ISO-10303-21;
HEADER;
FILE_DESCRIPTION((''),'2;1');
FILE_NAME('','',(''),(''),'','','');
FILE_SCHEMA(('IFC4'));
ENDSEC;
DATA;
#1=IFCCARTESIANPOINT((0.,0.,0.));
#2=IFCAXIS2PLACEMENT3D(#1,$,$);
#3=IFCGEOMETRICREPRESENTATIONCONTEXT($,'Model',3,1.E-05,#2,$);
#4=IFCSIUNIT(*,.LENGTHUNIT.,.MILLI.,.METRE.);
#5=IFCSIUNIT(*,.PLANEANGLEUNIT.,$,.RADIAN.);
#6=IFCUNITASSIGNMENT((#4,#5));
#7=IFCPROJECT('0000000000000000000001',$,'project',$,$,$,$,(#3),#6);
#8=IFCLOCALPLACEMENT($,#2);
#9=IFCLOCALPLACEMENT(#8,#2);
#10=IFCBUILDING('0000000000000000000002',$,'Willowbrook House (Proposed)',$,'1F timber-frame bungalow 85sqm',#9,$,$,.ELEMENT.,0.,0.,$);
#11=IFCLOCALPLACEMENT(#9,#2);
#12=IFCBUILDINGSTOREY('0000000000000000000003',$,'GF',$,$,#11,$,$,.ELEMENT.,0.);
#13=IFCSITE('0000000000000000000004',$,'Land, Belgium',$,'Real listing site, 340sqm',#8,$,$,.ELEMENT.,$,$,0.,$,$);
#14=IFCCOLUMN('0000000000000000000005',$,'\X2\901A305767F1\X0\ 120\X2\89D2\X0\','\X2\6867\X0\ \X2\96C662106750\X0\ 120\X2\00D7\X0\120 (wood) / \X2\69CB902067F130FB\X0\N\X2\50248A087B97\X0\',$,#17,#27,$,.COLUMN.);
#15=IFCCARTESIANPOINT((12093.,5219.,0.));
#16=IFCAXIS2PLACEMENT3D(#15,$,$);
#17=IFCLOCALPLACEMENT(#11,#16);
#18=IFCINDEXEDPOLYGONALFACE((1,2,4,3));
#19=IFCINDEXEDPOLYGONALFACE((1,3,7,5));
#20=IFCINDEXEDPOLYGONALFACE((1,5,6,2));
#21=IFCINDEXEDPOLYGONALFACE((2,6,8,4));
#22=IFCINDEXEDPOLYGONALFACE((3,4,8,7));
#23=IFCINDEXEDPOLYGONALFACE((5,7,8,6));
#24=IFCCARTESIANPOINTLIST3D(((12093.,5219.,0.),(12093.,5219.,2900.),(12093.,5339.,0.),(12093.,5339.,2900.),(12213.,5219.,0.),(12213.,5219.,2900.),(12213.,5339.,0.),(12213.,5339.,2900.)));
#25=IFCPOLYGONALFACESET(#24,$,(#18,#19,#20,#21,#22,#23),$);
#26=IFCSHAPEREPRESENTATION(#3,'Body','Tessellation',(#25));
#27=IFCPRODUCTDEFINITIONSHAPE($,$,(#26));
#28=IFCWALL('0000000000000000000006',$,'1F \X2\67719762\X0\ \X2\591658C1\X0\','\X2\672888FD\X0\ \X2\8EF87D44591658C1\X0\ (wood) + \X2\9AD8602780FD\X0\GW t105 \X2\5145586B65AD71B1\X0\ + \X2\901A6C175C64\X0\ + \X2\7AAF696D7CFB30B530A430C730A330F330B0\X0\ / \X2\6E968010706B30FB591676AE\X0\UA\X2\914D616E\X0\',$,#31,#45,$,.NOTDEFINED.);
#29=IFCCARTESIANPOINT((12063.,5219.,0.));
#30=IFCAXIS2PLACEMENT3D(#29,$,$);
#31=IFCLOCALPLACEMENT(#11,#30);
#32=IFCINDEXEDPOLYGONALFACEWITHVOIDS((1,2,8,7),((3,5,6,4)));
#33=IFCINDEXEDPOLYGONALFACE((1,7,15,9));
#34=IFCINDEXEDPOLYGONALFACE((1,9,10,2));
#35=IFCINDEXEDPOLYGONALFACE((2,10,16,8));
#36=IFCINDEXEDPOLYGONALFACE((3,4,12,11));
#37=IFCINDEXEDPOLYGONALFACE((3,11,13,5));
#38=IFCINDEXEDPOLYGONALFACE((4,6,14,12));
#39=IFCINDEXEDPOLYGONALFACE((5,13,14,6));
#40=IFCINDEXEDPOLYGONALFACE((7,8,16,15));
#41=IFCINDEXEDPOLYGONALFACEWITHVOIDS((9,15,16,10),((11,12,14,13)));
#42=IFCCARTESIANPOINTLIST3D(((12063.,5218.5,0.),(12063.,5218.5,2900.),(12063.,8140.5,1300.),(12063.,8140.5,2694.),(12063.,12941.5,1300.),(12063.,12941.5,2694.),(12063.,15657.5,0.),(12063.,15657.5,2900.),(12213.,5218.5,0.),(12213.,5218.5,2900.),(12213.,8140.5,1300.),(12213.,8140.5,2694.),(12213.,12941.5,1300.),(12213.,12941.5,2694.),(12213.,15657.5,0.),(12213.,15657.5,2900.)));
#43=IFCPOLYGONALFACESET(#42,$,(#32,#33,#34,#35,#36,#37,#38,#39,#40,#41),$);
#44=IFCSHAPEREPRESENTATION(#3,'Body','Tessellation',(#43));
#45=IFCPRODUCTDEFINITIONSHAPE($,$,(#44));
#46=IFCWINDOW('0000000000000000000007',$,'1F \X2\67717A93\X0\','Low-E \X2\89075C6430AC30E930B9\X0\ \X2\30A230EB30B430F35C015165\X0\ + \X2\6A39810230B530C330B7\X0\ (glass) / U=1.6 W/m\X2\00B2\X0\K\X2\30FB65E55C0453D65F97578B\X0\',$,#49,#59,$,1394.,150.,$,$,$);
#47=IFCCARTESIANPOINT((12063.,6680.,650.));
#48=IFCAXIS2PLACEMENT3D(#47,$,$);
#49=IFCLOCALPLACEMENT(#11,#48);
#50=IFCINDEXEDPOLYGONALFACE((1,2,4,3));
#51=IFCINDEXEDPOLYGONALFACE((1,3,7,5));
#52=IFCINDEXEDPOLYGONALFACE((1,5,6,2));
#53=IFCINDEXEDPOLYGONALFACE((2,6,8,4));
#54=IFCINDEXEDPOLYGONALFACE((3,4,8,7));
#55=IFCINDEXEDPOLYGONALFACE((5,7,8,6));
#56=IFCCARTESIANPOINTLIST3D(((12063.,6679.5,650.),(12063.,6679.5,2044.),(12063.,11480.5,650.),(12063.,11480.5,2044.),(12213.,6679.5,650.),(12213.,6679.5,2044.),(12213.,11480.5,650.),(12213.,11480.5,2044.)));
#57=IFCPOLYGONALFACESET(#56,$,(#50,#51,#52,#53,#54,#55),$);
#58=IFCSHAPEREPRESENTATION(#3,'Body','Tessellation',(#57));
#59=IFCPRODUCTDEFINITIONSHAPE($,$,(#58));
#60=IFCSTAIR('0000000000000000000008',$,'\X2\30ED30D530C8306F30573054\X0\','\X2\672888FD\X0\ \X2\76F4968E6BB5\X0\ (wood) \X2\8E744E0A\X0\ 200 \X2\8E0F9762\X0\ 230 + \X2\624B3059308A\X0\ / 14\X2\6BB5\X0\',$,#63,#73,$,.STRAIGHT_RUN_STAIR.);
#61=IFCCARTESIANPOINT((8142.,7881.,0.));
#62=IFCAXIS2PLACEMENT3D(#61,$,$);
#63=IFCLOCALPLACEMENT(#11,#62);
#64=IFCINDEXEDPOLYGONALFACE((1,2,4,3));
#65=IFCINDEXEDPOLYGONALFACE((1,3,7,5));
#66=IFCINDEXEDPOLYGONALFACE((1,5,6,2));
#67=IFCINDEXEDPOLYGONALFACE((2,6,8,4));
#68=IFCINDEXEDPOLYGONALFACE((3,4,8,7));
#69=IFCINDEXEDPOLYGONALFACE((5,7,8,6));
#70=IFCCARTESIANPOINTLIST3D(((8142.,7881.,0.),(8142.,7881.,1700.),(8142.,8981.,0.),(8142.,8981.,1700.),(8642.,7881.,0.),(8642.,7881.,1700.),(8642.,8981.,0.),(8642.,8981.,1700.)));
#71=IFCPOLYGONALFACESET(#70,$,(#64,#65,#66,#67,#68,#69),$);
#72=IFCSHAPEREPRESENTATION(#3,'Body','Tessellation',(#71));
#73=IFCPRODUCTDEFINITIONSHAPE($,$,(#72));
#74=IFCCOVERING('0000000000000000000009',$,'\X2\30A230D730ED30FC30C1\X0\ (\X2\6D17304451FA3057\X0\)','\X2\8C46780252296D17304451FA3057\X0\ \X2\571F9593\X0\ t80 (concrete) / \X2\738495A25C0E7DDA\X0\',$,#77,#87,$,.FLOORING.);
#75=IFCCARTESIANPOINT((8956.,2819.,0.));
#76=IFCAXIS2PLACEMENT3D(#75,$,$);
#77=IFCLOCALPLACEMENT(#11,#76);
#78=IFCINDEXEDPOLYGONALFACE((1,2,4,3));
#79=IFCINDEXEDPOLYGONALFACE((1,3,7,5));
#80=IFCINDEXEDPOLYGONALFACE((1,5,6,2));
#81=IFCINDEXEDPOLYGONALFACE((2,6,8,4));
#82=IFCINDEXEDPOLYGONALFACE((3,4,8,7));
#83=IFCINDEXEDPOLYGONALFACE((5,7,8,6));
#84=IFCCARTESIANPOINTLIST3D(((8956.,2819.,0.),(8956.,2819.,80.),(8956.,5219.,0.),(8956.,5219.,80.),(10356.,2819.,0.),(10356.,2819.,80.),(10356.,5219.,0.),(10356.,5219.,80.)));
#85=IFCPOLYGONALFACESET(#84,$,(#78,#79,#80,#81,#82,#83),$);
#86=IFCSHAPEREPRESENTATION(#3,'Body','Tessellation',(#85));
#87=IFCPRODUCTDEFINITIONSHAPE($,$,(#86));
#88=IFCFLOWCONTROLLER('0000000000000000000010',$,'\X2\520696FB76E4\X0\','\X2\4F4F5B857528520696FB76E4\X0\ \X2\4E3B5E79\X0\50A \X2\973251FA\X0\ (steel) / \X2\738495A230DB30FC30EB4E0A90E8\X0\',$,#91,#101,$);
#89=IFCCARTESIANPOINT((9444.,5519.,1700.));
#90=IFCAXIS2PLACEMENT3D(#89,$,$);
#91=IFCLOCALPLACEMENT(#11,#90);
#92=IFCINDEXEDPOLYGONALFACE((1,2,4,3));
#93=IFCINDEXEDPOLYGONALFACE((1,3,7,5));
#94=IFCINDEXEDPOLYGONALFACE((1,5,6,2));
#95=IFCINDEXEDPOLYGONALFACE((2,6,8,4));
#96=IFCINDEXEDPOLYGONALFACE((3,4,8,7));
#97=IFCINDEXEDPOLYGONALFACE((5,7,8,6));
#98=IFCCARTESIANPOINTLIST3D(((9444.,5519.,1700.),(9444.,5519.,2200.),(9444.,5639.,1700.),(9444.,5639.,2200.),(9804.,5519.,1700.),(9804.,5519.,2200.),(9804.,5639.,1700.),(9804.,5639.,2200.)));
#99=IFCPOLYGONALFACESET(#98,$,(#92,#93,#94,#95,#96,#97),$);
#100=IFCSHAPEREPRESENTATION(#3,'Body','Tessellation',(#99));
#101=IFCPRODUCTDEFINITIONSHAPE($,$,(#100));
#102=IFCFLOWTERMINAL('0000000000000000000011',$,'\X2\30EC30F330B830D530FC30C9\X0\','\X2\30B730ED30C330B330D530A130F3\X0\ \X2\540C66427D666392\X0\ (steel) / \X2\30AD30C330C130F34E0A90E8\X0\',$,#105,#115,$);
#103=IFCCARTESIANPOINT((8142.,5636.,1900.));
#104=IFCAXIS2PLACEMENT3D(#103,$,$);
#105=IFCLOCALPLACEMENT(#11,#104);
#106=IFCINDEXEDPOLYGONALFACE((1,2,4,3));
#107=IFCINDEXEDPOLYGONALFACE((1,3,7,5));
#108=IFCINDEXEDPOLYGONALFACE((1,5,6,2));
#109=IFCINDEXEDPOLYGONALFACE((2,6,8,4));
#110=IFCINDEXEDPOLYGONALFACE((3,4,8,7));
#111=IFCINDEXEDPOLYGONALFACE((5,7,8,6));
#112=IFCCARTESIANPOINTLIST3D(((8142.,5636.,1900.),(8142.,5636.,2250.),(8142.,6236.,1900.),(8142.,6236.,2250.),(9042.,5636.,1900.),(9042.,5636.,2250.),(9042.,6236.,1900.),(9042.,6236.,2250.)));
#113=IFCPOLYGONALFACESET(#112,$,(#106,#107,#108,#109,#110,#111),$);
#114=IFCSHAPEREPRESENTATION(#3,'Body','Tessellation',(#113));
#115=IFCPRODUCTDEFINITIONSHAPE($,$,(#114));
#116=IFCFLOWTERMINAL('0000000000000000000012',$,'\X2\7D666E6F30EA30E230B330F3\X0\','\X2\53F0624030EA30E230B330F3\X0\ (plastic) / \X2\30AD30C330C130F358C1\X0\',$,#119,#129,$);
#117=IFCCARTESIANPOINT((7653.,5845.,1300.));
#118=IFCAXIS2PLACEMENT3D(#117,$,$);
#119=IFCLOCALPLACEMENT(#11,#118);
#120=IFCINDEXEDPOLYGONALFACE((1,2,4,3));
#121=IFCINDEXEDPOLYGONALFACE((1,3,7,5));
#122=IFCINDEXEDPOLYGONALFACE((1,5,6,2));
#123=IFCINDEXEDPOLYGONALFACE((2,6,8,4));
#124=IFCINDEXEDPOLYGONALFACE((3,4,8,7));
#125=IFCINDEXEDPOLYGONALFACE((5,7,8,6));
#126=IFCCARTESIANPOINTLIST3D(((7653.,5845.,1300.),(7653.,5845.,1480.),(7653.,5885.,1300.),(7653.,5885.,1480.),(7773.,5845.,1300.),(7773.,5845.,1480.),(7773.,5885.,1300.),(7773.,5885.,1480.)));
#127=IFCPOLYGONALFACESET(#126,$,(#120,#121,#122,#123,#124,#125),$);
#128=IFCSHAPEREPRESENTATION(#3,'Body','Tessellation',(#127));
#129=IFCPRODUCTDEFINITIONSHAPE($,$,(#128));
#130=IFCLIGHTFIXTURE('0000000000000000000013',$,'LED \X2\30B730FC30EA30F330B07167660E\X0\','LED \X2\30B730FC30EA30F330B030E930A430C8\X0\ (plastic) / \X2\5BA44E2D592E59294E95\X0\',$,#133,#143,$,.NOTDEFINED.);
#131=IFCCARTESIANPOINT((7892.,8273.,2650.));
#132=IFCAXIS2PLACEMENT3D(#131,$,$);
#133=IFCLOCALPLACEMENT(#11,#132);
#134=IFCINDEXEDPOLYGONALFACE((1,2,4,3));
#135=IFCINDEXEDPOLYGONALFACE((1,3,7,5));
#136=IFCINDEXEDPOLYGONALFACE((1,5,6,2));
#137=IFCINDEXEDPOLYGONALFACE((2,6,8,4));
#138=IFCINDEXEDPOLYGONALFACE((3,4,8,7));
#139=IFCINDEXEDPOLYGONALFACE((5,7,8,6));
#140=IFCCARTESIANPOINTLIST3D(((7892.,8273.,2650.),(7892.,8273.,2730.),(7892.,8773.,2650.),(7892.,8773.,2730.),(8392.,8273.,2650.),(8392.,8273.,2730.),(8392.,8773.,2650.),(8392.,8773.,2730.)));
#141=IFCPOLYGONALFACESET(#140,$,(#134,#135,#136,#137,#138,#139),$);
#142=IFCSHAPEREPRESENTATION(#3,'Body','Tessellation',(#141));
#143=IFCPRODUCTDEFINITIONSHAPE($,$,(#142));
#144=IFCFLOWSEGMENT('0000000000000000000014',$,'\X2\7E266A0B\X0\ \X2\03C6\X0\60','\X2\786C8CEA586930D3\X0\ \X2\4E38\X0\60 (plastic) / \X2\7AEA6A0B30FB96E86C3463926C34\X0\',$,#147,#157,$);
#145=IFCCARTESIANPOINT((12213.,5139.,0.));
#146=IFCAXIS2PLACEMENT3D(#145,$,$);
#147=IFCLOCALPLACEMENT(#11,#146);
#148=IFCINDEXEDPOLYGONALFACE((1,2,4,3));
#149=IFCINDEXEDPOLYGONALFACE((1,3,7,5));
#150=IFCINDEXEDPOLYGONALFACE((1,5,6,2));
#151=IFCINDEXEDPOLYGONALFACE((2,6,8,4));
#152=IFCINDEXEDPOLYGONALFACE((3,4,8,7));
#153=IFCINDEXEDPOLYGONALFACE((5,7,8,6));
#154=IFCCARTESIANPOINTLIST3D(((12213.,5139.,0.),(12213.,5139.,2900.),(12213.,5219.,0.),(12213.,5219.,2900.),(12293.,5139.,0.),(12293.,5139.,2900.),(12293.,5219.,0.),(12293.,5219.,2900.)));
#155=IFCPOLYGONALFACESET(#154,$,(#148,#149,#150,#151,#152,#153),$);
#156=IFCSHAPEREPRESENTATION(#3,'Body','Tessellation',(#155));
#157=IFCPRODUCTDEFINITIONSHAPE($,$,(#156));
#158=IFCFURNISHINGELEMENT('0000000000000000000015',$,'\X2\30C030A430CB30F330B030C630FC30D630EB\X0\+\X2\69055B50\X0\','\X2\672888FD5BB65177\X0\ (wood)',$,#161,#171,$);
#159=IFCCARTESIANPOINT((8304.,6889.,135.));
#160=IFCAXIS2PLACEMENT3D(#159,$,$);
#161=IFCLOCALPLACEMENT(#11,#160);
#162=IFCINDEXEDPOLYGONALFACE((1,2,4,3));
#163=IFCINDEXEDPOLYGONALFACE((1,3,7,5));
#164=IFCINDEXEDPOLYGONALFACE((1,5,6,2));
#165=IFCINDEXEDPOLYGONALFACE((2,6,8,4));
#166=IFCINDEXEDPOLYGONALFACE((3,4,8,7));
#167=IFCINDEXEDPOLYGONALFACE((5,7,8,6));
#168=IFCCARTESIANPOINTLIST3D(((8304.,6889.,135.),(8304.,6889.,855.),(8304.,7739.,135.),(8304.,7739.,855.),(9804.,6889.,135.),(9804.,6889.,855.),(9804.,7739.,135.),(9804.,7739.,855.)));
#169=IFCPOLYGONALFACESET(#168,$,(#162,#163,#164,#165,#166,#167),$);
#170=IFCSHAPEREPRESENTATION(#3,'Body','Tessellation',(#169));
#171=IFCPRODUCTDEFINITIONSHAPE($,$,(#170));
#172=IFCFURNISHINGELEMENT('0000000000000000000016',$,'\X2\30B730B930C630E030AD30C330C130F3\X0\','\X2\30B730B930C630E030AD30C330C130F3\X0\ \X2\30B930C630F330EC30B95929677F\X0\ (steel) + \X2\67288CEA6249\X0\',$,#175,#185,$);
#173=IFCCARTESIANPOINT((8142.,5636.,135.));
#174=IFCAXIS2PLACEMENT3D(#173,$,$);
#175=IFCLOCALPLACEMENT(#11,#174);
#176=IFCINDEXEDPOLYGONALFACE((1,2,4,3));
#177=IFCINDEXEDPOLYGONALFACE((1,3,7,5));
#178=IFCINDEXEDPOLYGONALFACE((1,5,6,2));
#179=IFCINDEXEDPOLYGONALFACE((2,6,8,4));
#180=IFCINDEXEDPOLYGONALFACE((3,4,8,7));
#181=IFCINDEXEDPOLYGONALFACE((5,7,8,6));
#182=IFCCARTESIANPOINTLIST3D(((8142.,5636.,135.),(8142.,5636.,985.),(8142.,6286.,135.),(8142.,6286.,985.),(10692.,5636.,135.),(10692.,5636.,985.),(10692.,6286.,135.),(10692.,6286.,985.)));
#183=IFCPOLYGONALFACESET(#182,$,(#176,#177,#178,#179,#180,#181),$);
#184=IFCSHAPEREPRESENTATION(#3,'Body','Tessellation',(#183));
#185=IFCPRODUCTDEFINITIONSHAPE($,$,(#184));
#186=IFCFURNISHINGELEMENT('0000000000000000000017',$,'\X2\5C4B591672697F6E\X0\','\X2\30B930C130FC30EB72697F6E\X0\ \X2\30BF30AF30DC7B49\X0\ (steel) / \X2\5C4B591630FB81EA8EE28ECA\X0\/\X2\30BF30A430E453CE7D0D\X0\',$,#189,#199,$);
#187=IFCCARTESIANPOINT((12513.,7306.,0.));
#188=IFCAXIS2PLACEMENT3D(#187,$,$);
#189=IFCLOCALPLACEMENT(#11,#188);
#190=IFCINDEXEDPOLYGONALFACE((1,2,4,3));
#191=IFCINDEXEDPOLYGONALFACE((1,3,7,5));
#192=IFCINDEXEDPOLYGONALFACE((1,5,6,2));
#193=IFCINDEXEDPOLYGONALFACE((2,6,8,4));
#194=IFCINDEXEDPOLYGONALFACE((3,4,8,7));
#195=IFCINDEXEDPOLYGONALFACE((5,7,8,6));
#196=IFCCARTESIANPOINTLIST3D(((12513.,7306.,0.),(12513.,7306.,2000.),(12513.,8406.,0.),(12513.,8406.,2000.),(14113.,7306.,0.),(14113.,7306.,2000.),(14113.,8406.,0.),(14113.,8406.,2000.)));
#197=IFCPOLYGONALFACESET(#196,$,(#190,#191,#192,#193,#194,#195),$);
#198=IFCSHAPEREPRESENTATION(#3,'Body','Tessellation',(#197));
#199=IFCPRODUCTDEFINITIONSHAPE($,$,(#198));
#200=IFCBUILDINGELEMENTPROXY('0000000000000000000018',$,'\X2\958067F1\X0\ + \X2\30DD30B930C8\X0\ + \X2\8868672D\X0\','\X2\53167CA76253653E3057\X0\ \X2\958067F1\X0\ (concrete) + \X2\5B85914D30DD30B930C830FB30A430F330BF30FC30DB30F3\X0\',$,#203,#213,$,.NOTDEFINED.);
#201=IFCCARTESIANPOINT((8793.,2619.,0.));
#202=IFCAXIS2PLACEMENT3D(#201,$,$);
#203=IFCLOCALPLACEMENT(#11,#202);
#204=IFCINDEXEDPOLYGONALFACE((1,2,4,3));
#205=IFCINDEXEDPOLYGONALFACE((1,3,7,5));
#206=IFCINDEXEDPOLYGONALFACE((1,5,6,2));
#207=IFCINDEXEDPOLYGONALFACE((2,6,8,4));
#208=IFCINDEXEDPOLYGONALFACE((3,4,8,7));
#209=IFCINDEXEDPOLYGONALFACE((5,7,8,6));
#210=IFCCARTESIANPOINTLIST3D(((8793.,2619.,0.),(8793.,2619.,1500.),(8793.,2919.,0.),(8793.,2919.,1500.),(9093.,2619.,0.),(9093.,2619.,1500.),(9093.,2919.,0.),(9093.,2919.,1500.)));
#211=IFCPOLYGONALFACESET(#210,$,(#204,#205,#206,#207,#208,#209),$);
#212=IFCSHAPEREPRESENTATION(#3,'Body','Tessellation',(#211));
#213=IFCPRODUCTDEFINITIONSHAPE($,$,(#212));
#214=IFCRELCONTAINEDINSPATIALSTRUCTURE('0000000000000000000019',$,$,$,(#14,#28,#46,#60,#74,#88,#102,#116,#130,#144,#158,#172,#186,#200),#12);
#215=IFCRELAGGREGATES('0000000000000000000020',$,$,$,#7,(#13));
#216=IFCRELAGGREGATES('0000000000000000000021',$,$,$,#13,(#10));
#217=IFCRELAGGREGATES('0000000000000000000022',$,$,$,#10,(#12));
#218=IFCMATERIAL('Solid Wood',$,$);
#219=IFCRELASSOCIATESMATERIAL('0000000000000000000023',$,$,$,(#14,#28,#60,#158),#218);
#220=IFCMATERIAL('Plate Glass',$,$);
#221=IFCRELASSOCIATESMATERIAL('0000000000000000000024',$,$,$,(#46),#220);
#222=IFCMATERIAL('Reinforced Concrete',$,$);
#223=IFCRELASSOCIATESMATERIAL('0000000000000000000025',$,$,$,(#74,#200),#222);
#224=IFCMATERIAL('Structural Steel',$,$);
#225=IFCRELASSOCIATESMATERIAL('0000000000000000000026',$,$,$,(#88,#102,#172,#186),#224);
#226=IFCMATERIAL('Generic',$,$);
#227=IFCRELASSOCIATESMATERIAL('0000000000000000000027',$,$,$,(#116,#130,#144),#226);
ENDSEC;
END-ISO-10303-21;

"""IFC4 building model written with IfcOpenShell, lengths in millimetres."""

from ifc_helpers import new_model, si_unit, frame, frame_2d, origin, place, context, project, spatial, rectangle, extrude, material, element, fill, save


model = new_model("IFC4")

# Units and contexts
model_context = context("Model", 3, precision=1e-05, world=origin())
ifc_project = project(units=[si_unit("LENGTHUNIT", "METRE", prefix="MILLI"), si_unit("PLANEANGLEUNIT", "RADIAN")], contexts=[model_context])

# Site, building, storey
site_placement = place(None, origin())
site = spatial("IfcSite", under=ifc_project, at=site_placement, Name="Land, Belgium", ObjectType="Real listing site, 340sqm", CompositionType="ELEMENT", RefElevation=0.0)
building_placement = place(site_placement, origin())
building = spatial("IfcBuilding", under=site, at=building_placement, Name="Willowbrook House (Proposed)", ObjectType="1F timber-frame bungalow 85sqm", CompositionType="ELEMENT", ElevationOfRefHeight=0.0, ElevationOfTerrain=0.0)
storey_placement = place(building_placement, origin())
storey = spatial("IfcBuildingStorey", under=building, at=storey_placement, Name="GF", CompositionType="ELEMENT", Elevation=0.0)

# Column
ifc_material_1 = material(Name="Solid Wood")
column_1_placement = place(storey_placement, frame((12093.0, 5219.0, 0.0)))
element("IfcColumn", 1, at=column_1_placement, inside=storey, material=ifc_material_1, Name="通し柱 120角", Description="桧 集成材 120×120 (wood) / 構造柱・N値計算", PredefinedType="COLUMN", context=model_context, shape_type="SweptSolid", body=[
    extrude(rectangle(XDim=120.0, YDim=120.0, at=frame_2d((60.0, 60.0))), frame((12093.0, 5219.0, 0.0)), (0.0, 0.0, 1.0), 2900.0),
])

# Wall, opening, window
wall_1_placement = place(storey_placement, frame((12063.0, 5219.0, 0.0)))
wall_1 = element("IfcWall", 2, at=wall_1_placement, inside=storey, material=ifc_material_1, Name="1F 東面 外壁", Description="木製 軸組外壁 (wood) + 高性能GW t105 充填断熱 + 通気層 + 窯業系サイディング / 準耐火・外皮UA配慮", PredefinedType="NOTDEFINED", context=model_context, shape_type="SweptSolid", body=[
    extrude(rectangle(XDim=150.0, YDim=10439.0, at=frame_2d((75.0, 5219.0))), frame((12063.0, 5219.0, 0.0)), (0.0, 0.0, 1.0), 2900.0),
])
opening_placement = place(storey_placement, frame((12063.0, 6680.0, 650.0)))
opening = element("IfcOpeningElement", 3, at=opening_placement, cuts=wall_1, PredefinedType="NOTDEFINED", context=model_context, shape_type="SweptSolid", body=[
    extrude(rectangle(XDim=150.0, YDim=4801.0, at=frame_2d((75.0, 2400.0))), frame((12063.0, 6680.0, 650.0)), (0.0, 0.0, 1.0), 1394.0),
])
ifc_material_2 = material(Name="Plate Glass")
window_placement = place(storey_placement, frame((12063.0, 6680.0, 650.0)))
window = element("IfcWindow", 4, at=window_placement, inside=storey, material=ifc_material_2, Name="1F 東窓", Description="Low-E 複層ガラス アルゴン封入 + 樹脂サッシ (glass) / U=1.6 W/m²K・日射取得型", OverallHeight=1394.0, OverallWidth=150.0, context=model_context, shape_type="SweptSolid", body=[
    extrude(rectangle(XDim=150.0, YDim=4801.0, at=frame_2d((75.0, 2400.0))), frame((12063.0, 6680.0, 650.0)), (0.0, 0.0, 1.0), 1394.0),
])
fill(opening, window)

# Stair
stair_placement = place(storey_placement, frame((8142.0, 7881.0, 0.0)))
element("IfcStair", 5, at=stair_placement, inside=storey, material=ifc_material_1, Name="ロフトはしご", Description="木製 直階段 (wood) 蹴上 200 踏面 230 + 手すり / 14段", PredefinedType="STRAIGHT_RUN_STAIR", context=model_context, shape_type="SweptSolid", body=[
    extrude(rectangle(XDim=500.0, YDim=1100.0, at=frame_2d((250.0, 550.0))), frame((8142.0, 7881.0, 0.0)), (0.0, 0.0, 1.0), 1700.0),
])

# Covering
ifc_material_3 = material(Name="Reinforced Concrete")
covering_placement = place(storey_placement, frame((8956.0, 2819.0, 0.0)))
element("IfcCovering", 6, at=covering_placement, inside=storey, material=ifc_material_3, Name="アプローチ (洗い出し)", Description="豆砂利洗い出し 土間 t80 (concrete) / 玄関導線", PredefinedType="FLOORING", context=model_context, shape_type="SweptSolid", body=[
    extrude(rectangle(XDim=1400.0, YDim=2400.0, at=frame_2d((700.0, 1200.0))), frame((8956.0, 2819.0, 0.0)), (0.0, 0.0, 1.0), 80.0),
])

# Flow controller
ifc_material_4 = material(Name="Structural Steel")
flow_controller_placement = place(storey_placement, frame((9444.0, 5519.0, 1700.0)))
element("IfcFlowController", 7, at=flow_controller_placement, inside=storey, material=ifc_material_4, Name="分電盤", Description="住宅用分電盤 主幹50A 露出 (steel) / 玄関ホール上部", context=model_context, shape_type="SweptSolid", body=[
    extrude(rectangle(XDim=360.0, YDim=120.0, at=frame_2d((180.0, 60.0))), frame((9444.0, 5519.0, 1700.0)), (0.0, 0.0, 1.0), 500.0),
])

# Flow terminals
flow_terminal_1_placement = place(storey_placement, frame((8142.0, 5636.0, 1900.0)))
element("IfcFlowTerminal", 8, at=flow_terminal_1_placement, inside=storey, material=ifc_material_4, Name="レンジフード", Description="シロッコファン 同時給排 (steel) / キッチン上部", context=model_context, shape_type="SweptSolid", body=[
    extrude(rectangle(XDim=900.0, YDim=600.0, at=frame_2d((450.0, 300.0))), frame((8142.0, 5636.0, 1900.0)), (0.0, 0.0, 1.0), 350.0),
])
ifc_material_5 = material(Name="Generic")
flow_terminal_2_placement = place(storey_placement, frame((7653.0, 5845.0, 1300.0)))
element("IfcFlowTerminal", 9, at=flow_terminal_2_placement, inside=storey, material=ifc_material_5, Name="給湯リモコン", Description="台所リモコン (plastic) / キッチン壁", context=model_context, shape_type="SweptSolid", body=[
    extrude(rectangle(XDim=120.0, YDim=40.0, at=frame_2d((60.0, 20.0))), frame((7653.0, 5845.0, 1300.0)), (0.0, 0.0, 1.0), 180.0),
])

# Light fixture
light_fixture_placement = place(storey_placement, frame((7892.0, 8273.0, 2650.0)))
element("IfcLightFixture", 10, at=light_fixture_placement, inside=storey, material=ifc_material_5, Name="LED シーリング照明", Description="LED シーリングライト (plastic) / 室中央天井", PredefinedType="NOTDEFINED", context=model_context, shape_type="SweptSolid", body=[
    extrude(rectangle(XDim=500.0, YDim=500.0, at=frame_2d((250.0, 250.0))), frame((7892.0, 8273.0, 2650.0)), (0.0, 0.0, 1.0), 80.0),
])

# Flow segment
flow_segment_placement = place(storey_placement, frame((12213.0, 5139.0, 0.0)))
element("IfcFlowSegment", 11, at=flow_segment_placement, inside=storey, material=ifc_material_5, Name="縦樋 φ60", Description="硬質塩ビ 丸60 (plastic) / 竪樋・雨水排水", context=model_context, shape_type="SweptSolid", body=[
    extrude(rectangle(XDim=80.0, YDim=80.0, at=frame_2d((40.0, 40.0))), frame((12213.0, 5139.0, 0.0)), (0.0, 0.0, 1.0), 2900.0),
])

# Furnishing elements
furnishing_1_placement = place(storey_placement, frame((8304.0, 6889.0, 135.0)))
element("IfcFurnishingElement", 12, at=furnishing_1_placement, inside=storey, material=ifc_material_1, Name="ダイニングテーブル+椅子", Description="木製家具 (wood)", context=model_context, shape_type="SweptSolid", body=[
    extrude(rectangle(XDim=1500.0, YDim=850.0, at=frame_2d((750.0, 425.0))), frame((8304.0, 6889.0, 135.0)), (0.0, 0.0, 1.0), 720.0),
])
furnishing_2_placement = place(storey_placement, frame((8142.0, 5636.0, 135.0)))
element("IfcFurnishingElement", 13, at=furnishing_2_placement, inside=storey, material=ifc_material_4, Name="システムキッチン", Description="システムキッチン ステンレス天板 (steel) + 木質扉", context=model_context, shape_type="SweptSolid", body=[
    extrude(rectangle(XDim=2550.0, YDim=650.0, at=frame_2d((1275.0, 325.0))), frame((8142.0, 5636.0, 135.0)), (0.0, 0.0, 1.0), 850.0),
])
furnishing_3_placement = place(storey_placement, frame((12513.0, 7306.0, 0.0)))
element("IfcFurnishingElement", 14, at=furnishing_3_placement, inside=storey, material=ifc_material_4, Name="屋外物置", Description="スチール物置 タクボ等 (steel) / 屋外・自転車/タイヤ収納", context=model_context, shape_type="SweptSolid", body=[
    extrude(rectangle(XDim=1600.0, YDim=1100.0, at=frame_2d((800.0, 550.0))), frame((12513.0, 7306.0, 0.0)), (0.0, 0.0, 1.0), 2000.0),
])

# Building element proxy
proxy_placement = place(storey_placement, frame((8793.0, 2619.0, 0.0)))
element("IfcBuildingElementProxy", 15, at=proxy_placement, inside=storey, material=ifc_material_3, Name="門柱 + ポスト + 表札", Description="化粧打放し 門柱 (concrete) + 宅配ポスト・インターホン", PredefinedType="NOTDEFINED", context=model_context, shape_type="SweptSolid", body=[
    extrude(rectangle(XDim=300.0, YDim=300.0, at=frame_2d((150.0, 150.0))), frame((8793.0, 2619.0, 0.0)), (0.0, 0.0, 1.0), 1500.0),
])

save(model, "model.ifc")
